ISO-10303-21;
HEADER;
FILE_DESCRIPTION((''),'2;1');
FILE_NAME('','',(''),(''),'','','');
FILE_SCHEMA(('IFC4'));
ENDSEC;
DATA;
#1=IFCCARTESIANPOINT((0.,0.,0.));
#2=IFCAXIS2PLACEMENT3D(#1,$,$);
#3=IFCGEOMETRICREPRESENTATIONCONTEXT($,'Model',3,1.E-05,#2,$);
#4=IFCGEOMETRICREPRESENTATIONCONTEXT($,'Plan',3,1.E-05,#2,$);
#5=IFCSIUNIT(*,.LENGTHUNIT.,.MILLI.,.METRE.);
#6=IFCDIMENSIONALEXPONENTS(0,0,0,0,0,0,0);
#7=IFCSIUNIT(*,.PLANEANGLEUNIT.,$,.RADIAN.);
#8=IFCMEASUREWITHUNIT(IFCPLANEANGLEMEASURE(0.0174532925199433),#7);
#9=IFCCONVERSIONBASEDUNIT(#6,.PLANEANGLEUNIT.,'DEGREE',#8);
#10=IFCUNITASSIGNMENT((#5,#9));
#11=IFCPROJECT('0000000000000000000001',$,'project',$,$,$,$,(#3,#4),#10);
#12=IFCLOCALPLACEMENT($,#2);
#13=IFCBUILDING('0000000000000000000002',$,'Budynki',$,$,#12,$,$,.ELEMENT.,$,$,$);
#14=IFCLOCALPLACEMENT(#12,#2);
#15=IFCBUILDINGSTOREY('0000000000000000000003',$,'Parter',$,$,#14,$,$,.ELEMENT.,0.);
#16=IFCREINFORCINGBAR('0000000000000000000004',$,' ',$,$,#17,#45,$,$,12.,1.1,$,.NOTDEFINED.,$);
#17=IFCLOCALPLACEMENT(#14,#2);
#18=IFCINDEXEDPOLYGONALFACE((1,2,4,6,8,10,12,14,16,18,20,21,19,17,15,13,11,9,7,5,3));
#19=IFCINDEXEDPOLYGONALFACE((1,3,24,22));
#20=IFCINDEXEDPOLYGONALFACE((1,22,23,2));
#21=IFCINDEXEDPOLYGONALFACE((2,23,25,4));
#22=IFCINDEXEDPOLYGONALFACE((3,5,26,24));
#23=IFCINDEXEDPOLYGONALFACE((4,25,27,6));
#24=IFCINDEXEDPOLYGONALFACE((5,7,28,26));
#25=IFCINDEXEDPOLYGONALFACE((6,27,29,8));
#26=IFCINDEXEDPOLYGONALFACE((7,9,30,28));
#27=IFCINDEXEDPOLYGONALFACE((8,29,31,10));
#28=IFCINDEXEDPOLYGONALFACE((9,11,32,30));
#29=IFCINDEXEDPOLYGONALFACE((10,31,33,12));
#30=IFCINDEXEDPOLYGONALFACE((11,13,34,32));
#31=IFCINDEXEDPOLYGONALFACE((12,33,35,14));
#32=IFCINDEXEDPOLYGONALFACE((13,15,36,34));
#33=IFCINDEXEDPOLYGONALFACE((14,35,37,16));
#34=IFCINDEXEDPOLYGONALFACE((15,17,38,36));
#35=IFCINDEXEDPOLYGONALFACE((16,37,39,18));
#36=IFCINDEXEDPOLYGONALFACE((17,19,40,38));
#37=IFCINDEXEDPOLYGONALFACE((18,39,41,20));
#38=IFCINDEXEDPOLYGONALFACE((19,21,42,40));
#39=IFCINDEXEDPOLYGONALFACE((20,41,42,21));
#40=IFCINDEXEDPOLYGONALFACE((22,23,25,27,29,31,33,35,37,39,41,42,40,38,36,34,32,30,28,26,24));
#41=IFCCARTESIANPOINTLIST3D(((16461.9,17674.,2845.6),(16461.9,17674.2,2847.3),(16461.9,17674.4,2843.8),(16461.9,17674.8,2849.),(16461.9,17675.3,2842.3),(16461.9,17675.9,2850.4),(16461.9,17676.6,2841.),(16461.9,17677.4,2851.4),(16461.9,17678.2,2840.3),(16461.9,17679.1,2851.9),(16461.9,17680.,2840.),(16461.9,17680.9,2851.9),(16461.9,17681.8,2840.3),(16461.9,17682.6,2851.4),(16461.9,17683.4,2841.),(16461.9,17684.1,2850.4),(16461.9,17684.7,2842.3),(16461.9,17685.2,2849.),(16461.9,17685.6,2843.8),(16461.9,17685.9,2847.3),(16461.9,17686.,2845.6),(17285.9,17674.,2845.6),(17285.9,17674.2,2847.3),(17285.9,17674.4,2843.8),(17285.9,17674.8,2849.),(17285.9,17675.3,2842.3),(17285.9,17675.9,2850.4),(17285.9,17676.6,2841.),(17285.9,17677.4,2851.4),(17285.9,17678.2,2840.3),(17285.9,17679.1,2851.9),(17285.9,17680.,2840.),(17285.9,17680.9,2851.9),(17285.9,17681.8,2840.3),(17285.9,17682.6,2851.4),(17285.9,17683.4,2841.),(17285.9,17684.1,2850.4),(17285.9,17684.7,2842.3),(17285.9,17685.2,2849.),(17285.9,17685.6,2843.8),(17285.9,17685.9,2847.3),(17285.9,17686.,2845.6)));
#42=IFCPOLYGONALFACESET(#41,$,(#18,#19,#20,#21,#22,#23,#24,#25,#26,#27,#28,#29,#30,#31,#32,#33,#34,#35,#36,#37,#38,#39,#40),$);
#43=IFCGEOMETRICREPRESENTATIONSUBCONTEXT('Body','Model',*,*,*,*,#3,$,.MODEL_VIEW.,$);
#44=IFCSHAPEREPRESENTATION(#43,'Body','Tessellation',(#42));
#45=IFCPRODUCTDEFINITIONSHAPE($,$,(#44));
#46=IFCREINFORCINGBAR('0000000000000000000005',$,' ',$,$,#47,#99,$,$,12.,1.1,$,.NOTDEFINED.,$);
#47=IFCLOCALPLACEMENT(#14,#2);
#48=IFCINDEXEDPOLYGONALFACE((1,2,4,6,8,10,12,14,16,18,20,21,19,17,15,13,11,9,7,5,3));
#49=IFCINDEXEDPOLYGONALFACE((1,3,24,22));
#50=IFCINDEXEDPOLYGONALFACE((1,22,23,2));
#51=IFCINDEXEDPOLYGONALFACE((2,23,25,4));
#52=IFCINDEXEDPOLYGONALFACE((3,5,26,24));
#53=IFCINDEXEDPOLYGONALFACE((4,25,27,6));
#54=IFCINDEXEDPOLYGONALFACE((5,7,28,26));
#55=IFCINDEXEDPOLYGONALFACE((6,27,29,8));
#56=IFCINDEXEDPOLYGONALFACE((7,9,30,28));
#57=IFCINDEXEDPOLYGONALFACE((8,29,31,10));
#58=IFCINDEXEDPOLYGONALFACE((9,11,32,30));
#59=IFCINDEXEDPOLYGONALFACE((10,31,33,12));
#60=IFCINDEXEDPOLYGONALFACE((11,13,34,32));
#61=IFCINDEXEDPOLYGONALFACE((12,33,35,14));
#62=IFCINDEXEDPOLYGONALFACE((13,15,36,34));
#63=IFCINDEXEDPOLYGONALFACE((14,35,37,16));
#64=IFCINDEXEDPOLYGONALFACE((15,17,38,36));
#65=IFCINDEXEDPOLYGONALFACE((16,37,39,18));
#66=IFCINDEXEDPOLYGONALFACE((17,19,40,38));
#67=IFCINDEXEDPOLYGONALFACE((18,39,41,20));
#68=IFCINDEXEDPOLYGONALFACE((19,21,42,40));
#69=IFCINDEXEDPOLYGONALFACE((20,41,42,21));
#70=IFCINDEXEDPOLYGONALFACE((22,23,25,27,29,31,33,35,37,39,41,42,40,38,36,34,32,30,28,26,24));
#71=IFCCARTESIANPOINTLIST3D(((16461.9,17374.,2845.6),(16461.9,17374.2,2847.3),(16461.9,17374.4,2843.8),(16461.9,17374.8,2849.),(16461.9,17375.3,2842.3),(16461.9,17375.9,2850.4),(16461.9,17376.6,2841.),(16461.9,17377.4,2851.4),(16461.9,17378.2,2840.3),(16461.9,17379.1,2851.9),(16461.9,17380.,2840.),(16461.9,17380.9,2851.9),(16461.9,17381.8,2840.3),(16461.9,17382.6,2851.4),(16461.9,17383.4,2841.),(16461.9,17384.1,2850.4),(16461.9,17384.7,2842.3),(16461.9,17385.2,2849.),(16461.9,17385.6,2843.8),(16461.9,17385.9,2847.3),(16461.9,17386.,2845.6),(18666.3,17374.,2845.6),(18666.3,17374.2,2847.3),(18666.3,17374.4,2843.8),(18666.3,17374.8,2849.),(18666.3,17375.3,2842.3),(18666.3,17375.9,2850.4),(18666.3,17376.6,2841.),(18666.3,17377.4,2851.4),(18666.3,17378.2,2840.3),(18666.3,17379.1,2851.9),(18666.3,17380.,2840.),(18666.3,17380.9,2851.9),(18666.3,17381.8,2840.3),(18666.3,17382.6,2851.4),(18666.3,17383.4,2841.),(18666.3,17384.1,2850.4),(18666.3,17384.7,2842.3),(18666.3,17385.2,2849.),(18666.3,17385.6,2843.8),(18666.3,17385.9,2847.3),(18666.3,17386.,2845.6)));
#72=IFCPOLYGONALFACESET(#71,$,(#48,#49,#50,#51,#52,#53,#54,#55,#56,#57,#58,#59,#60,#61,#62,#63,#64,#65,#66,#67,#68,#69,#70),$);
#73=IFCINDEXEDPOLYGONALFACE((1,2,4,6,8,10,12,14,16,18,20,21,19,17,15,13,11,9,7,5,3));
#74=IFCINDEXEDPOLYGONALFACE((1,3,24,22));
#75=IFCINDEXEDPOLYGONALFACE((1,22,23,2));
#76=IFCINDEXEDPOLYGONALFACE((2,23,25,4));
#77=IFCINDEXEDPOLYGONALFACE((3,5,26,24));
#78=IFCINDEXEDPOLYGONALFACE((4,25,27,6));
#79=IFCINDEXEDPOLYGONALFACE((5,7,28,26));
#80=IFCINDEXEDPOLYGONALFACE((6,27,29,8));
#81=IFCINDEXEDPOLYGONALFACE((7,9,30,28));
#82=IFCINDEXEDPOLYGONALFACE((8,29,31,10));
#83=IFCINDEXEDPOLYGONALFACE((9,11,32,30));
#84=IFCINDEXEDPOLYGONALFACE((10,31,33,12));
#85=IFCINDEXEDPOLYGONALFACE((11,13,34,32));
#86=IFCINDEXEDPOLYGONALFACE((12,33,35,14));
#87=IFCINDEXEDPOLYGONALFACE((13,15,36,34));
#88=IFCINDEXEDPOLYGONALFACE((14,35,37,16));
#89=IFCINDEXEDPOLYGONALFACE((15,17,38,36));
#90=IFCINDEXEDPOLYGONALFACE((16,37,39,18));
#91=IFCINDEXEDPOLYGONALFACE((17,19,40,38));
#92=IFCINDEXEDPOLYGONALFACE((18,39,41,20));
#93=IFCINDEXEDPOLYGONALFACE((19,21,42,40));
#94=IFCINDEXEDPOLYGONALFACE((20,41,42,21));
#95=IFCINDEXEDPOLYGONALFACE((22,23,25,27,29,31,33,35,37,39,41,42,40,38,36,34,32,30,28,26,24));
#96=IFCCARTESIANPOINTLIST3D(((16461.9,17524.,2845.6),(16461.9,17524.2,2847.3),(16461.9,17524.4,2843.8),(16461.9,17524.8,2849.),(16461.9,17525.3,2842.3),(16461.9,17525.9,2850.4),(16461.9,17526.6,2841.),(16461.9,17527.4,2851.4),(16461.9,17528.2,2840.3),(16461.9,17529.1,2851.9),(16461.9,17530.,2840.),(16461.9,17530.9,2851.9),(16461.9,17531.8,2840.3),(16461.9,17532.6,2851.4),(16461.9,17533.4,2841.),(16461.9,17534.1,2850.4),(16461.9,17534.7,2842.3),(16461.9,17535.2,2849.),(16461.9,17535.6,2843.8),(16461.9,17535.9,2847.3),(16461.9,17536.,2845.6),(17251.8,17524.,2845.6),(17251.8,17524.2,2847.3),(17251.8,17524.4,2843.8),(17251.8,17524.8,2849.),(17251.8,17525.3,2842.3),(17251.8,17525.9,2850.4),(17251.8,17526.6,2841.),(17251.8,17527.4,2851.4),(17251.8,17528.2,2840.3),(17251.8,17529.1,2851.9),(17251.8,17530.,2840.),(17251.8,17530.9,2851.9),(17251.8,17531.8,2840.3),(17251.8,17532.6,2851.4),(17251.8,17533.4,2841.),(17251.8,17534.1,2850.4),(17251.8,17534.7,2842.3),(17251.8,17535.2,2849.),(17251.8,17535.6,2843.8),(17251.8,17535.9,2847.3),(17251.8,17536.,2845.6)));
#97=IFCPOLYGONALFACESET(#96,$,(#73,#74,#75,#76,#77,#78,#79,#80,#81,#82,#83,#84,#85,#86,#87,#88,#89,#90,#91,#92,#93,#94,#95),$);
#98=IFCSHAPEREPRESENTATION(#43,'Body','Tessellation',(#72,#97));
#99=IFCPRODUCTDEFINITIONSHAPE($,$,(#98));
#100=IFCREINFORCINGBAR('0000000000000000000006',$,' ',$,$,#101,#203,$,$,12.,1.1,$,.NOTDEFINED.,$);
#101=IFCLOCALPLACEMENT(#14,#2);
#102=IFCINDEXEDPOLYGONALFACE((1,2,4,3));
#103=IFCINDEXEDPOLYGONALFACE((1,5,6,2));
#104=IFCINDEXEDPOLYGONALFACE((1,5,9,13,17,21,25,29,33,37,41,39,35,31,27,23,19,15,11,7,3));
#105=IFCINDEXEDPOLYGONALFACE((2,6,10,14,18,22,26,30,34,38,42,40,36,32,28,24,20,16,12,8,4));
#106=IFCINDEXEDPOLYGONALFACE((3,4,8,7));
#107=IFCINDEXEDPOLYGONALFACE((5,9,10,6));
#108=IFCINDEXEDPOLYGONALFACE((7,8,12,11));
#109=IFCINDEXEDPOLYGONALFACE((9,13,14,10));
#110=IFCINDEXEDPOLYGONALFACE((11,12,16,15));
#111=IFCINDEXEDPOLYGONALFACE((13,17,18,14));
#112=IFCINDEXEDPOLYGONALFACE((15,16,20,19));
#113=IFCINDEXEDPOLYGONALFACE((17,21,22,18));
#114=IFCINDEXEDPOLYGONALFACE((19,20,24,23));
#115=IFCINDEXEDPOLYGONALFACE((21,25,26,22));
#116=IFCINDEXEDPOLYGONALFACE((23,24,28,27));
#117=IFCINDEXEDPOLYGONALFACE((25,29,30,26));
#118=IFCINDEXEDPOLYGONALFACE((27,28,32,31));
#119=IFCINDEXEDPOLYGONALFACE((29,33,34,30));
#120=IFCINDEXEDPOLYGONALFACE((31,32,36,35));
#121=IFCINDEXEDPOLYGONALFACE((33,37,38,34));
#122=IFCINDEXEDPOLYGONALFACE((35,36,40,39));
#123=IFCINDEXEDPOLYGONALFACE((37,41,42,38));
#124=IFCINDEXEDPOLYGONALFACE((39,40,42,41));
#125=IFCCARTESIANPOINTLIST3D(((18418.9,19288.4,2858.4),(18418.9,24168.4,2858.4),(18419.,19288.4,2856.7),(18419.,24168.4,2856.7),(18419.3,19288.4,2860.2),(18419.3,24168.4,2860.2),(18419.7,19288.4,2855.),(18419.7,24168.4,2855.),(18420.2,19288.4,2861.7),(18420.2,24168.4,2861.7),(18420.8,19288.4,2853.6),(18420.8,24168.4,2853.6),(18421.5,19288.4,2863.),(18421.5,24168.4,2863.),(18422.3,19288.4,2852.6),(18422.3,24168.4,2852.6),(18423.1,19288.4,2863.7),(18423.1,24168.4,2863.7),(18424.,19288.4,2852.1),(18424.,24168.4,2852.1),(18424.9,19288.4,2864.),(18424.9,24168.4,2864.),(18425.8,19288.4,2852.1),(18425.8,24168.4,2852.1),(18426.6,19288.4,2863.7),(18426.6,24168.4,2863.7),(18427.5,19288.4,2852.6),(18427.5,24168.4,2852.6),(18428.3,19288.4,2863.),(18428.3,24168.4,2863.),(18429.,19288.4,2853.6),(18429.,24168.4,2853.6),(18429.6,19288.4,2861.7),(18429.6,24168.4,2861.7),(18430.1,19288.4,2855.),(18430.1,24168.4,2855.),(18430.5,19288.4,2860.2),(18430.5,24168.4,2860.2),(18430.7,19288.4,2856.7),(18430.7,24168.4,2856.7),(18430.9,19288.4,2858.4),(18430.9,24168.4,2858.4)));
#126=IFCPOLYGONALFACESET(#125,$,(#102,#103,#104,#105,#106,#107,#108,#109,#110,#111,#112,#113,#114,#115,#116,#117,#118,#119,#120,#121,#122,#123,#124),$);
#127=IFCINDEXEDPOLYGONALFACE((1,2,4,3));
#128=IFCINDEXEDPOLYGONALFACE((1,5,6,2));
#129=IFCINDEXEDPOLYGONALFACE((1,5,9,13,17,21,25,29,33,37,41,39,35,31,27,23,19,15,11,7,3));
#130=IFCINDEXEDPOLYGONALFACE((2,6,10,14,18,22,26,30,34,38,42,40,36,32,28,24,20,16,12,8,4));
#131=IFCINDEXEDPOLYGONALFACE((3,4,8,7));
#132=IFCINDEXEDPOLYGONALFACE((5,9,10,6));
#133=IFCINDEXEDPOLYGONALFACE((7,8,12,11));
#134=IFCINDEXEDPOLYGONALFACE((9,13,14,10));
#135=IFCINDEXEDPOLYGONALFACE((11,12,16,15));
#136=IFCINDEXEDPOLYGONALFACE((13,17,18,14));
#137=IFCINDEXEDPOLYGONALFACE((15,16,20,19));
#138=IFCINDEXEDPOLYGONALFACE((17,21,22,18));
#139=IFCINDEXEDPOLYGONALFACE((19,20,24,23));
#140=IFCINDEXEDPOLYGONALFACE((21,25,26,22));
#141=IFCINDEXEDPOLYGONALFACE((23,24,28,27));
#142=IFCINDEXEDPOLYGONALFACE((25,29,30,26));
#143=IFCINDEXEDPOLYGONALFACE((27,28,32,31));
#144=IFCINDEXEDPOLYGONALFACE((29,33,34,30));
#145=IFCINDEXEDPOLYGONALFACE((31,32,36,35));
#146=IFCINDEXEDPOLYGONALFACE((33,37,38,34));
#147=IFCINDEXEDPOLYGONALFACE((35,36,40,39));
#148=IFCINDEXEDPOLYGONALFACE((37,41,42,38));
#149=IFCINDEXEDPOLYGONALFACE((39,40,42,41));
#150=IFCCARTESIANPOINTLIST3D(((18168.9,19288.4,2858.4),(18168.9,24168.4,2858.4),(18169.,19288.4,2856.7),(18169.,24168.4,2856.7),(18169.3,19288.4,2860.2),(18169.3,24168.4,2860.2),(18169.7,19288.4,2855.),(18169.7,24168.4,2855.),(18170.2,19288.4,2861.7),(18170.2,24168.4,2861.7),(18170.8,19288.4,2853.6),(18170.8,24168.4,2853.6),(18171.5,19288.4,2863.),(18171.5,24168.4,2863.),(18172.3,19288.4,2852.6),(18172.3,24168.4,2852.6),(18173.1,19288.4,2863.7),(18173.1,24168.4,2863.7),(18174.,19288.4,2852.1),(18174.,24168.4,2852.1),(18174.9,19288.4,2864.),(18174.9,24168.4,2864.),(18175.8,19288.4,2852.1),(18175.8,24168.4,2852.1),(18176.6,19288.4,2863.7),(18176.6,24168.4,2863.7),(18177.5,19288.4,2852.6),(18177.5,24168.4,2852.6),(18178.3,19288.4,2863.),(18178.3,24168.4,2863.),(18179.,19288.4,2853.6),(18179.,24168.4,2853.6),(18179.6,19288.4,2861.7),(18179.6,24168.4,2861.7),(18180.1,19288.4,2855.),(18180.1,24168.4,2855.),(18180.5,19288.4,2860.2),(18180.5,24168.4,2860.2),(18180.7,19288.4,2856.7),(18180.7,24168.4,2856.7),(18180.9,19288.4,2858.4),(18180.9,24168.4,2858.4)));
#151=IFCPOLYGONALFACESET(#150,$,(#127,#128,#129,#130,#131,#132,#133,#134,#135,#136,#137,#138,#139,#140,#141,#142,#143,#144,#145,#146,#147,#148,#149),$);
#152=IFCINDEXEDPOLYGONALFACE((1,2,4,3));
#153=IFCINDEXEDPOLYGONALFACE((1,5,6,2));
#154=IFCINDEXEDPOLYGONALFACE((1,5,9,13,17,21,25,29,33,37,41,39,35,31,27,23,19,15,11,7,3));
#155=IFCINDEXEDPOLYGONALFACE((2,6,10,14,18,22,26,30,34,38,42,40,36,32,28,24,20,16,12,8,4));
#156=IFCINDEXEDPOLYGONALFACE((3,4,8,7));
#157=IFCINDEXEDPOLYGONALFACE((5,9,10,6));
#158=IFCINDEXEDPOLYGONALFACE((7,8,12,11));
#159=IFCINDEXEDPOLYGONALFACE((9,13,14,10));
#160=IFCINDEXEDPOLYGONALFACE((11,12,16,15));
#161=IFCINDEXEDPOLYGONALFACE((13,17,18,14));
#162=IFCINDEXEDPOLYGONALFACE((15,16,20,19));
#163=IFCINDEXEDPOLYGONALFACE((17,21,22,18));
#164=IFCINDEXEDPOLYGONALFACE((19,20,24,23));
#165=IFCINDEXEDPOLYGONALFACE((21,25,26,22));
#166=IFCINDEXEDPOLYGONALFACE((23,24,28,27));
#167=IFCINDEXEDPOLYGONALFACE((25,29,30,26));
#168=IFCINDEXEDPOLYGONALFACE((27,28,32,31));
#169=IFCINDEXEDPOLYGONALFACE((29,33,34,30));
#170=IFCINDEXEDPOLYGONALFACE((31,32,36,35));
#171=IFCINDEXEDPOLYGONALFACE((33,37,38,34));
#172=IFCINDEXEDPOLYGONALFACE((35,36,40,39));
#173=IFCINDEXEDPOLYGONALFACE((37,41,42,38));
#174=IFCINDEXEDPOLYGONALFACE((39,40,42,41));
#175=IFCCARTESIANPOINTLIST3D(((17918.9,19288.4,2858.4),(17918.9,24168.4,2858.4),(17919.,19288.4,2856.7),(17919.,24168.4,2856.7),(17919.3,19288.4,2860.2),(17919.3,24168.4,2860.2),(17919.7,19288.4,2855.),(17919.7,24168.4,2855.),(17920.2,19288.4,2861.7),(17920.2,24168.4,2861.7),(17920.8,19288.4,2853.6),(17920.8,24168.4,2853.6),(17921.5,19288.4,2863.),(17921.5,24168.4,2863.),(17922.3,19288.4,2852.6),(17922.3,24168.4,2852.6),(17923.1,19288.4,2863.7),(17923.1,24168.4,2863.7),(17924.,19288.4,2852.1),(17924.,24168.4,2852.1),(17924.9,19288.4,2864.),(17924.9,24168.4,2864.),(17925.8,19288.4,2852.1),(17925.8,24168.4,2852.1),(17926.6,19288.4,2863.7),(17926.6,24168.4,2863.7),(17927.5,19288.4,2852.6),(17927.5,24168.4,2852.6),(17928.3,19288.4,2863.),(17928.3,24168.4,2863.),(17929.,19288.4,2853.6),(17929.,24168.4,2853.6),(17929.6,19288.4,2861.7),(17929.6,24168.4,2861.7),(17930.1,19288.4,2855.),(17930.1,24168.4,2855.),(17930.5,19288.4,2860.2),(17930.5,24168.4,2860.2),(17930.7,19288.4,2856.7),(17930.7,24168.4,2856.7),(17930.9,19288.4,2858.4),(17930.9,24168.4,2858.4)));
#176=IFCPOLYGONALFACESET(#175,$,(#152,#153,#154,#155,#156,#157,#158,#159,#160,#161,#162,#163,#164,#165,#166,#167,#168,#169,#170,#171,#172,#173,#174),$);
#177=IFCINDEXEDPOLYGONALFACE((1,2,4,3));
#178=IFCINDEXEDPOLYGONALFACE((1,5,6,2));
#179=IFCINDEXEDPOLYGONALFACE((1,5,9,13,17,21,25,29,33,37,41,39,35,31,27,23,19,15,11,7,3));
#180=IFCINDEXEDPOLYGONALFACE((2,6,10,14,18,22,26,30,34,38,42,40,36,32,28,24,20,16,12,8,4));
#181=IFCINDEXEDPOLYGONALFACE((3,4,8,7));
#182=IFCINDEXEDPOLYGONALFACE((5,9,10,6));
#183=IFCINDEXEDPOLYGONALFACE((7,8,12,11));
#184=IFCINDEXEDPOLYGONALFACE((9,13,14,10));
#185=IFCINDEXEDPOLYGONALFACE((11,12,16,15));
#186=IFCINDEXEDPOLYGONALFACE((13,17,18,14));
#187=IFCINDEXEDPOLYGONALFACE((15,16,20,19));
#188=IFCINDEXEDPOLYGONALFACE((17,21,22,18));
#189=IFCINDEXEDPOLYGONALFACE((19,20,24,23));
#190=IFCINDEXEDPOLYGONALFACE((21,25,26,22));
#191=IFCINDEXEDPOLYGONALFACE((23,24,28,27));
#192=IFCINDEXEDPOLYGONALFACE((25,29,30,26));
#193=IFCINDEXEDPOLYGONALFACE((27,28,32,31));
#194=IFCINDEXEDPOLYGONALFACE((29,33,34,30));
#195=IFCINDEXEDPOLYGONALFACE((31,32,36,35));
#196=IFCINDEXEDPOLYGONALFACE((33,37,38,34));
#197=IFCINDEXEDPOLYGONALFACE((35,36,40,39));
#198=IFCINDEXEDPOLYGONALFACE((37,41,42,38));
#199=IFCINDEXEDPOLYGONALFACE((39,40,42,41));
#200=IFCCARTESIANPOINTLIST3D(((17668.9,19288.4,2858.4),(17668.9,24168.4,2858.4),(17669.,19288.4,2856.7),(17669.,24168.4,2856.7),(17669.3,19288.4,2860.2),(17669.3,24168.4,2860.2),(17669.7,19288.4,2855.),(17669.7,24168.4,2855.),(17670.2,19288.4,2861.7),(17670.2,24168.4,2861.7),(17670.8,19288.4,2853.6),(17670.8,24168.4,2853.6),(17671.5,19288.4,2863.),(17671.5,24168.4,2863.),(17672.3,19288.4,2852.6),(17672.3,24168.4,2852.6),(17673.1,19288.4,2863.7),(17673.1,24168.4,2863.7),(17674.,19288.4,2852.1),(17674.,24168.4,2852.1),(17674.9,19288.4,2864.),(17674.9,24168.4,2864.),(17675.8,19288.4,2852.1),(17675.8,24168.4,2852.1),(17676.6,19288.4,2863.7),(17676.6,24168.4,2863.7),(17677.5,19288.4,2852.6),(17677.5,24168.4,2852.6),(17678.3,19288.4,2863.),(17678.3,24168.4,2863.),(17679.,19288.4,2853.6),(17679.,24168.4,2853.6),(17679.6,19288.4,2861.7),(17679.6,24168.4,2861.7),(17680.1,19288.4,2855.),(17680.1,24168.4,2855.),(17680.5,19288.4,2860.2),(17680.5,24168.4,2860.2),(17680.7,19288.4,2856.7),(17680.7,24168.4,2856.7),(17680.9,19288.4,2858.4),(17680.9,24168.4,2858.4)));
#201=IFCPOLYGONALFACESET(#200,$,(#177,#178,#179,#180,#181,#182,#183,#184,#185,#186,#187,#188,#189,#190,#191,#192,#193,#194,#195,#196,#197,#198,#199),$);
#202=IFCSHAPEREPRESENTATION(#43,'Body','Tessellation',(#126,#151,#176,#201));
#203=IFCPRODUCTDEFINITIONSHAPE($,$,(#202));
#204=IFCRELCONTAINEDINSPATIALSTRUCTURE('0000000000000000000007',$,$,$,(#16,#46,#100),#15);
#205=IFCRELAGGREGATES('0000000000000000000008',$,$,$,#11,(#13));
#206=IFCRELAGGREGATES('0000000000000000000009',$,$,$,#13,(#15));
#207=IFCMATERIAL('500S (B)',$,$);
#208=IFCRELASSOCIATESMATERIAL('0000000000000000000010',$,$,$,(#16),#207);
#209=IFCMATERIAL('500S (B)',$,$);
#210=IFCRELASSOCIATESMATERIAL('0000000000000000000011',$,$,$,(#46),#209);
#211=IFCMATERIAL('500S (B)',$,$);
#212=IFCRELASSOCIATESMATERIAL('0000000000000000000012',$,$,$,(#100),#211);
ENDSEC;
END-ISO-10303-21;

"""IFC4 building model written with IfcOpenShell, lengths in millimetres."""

from ifc_helpers import new_model, entity, si_unit, converted_unit, frame, origin, place, context, subcontext, project, spatial, material, element, save


model = new_model("IFC4")

# Units and contexts
model_context = context("Model", 3, precision=1e-05, world=origin())
plan_context = context("Plan", 3, precision=1e-05, world=origin())
body_context = subcontext(model_context, "Body", "Model", "MODEL_VIEW")
ifc_project = project(units=[si_unit("LENGTHUNIT", "METRE", prefix="MILLI"), converted_unit("PLANEANGLEUNIT", "DEGREE", entity("IfcPlaneAngleMeasure", 0.0174532925199433), si_unit("PLANEANGLEUNIT", "RADIAN"), dimensions=[0, 0, 0, 0, 0, 0, 0])], contexts=[model_context, plan_context])

# Building, storey
building_placement = place(None, origin())
building = spatial("IfcBuilding", under=ifc_project, at=building_placement, Name="Budynki", CompositionType="ELEMENT")
storey_placement = place(building_placement, origin())
storey = spatial("IfcBuildingStorey", under=building, at=storey_placement, Name="Parter", CompositionType="ELEMENT", Elevation=0.0)

# Reinforcing bars
ifc_material_1 = material(Name="500S (B)")
reinforcing_bar_1_placement = place(storey_placement, frame((17285.9, 17680.0, 2846.0)))
element("IfcReinforcingBar", 1, at=reinforcing_bar_1_placement, inside=storey, material=ifc_material_1, Name=" ", CrossSectionArea=1.1, NominalDiameter=12.0, PredefinedType="NOTDEFINED", context=body_context, shape_type="AdvancedSweptSolid", body=[
    entity("IfcSweptDiskSolid", entity("IfcPolyline", [entity("IfcCartesianPoint", [0.0, 0.0, 0.0]), entity("IfcCartesianPoint", [-824.1, 0.0, 0.0])]), 6.0, None, 0.0, 1.0),
])
ifc_material_2 = material(Name="500S (B)")
reinforcing_bar_2_placement = place(storey_placement, frame((18666.3, 17380.0, 2846.0)))
element("IfcReinforcingBar", 2, at=reinforcing_bar_2_placement, inside=storey, material=ifc_material_2, Name=" ", CrossSectionArea=1.1, NominalDiameter=12.0, PredefinedType="NOTDEFINED", context=body_context, shape_type="AdvancedSweptSolid", body=[
    entity("IfcSweptDiskSolid", entity("IfcPolyline", [entity("IfcCartesianPoint", [0.0, 0.0, 0.0]), entity("IfcCartesianPoint", [-2204.4, 0.0, 0.0])]), 6.0, None, 0.0, 1.0),
    entity("IfcSweptDiskSolid", entity("IfcPolyline", [entity("IfcCartesianPoint", [-1414.5, 150.0, 0.0]), entity("IfcCartesianPoint", [-2204.4, 150.0, 0.0])]), 6.0, None, 0.0, 1.0),
])
ifc_material_3 = material(Name="500S (B)")
reinforcing_bar_3_placement = place(storey_placement, frame((18424.9, 19288.4, 2858.0)))
element("IfcReinforcingBar", 3, at=reinforcing_bar_3_placement, inside=storey, material=ifc_material_3, Name=" ", CrossSectionArea=1.1, NominalDiameter=12.0, PredefinedType="NOTDEFINED", context=body_context, shape_type="AdvancedSweptSolid", body=[
    entity("IfcSweptDiskSolid", entity("IfcPolyline", [entity("IfcCartesianPoint", [0.0, 0.0, 0.0]), entity("IfcCartesianPoint", [0.0, 4880.0, 0.0])]), 6.0, None, 0.0, 1.0),
    entity("IfcSweptDiskSolid", entity("IfcPolyline", [entity("IfcCartesianPoint", [-250.0, 0.0, 0.0]), entity("IfcCartesianPoint", [-250.0, 4880.0, 0.0])]), 6.0, None, 0.0, 1.0),
    entity("IfcSweptDiskSolid", entity("IfcPolyline", [entity("IfcCartesianPoint", [-500.0, 0.0, 0.0]), entity("IfcCartesianPoint", [-500.0, 4880.0, 0.0])]), 6.0, None, 0.0, 1.0),
    entity("IfcSweptDiskSolid", entity("IfcPolyline", [entity("IfcCartesianPoint", [-750.0, 0.0, 0.0]), entity("IfcCartesianPoint", [-750.0, 4880.0, 0.0])]), 6.0, None, 0.0, 1.0),
])

save(model, "model.ifc")
